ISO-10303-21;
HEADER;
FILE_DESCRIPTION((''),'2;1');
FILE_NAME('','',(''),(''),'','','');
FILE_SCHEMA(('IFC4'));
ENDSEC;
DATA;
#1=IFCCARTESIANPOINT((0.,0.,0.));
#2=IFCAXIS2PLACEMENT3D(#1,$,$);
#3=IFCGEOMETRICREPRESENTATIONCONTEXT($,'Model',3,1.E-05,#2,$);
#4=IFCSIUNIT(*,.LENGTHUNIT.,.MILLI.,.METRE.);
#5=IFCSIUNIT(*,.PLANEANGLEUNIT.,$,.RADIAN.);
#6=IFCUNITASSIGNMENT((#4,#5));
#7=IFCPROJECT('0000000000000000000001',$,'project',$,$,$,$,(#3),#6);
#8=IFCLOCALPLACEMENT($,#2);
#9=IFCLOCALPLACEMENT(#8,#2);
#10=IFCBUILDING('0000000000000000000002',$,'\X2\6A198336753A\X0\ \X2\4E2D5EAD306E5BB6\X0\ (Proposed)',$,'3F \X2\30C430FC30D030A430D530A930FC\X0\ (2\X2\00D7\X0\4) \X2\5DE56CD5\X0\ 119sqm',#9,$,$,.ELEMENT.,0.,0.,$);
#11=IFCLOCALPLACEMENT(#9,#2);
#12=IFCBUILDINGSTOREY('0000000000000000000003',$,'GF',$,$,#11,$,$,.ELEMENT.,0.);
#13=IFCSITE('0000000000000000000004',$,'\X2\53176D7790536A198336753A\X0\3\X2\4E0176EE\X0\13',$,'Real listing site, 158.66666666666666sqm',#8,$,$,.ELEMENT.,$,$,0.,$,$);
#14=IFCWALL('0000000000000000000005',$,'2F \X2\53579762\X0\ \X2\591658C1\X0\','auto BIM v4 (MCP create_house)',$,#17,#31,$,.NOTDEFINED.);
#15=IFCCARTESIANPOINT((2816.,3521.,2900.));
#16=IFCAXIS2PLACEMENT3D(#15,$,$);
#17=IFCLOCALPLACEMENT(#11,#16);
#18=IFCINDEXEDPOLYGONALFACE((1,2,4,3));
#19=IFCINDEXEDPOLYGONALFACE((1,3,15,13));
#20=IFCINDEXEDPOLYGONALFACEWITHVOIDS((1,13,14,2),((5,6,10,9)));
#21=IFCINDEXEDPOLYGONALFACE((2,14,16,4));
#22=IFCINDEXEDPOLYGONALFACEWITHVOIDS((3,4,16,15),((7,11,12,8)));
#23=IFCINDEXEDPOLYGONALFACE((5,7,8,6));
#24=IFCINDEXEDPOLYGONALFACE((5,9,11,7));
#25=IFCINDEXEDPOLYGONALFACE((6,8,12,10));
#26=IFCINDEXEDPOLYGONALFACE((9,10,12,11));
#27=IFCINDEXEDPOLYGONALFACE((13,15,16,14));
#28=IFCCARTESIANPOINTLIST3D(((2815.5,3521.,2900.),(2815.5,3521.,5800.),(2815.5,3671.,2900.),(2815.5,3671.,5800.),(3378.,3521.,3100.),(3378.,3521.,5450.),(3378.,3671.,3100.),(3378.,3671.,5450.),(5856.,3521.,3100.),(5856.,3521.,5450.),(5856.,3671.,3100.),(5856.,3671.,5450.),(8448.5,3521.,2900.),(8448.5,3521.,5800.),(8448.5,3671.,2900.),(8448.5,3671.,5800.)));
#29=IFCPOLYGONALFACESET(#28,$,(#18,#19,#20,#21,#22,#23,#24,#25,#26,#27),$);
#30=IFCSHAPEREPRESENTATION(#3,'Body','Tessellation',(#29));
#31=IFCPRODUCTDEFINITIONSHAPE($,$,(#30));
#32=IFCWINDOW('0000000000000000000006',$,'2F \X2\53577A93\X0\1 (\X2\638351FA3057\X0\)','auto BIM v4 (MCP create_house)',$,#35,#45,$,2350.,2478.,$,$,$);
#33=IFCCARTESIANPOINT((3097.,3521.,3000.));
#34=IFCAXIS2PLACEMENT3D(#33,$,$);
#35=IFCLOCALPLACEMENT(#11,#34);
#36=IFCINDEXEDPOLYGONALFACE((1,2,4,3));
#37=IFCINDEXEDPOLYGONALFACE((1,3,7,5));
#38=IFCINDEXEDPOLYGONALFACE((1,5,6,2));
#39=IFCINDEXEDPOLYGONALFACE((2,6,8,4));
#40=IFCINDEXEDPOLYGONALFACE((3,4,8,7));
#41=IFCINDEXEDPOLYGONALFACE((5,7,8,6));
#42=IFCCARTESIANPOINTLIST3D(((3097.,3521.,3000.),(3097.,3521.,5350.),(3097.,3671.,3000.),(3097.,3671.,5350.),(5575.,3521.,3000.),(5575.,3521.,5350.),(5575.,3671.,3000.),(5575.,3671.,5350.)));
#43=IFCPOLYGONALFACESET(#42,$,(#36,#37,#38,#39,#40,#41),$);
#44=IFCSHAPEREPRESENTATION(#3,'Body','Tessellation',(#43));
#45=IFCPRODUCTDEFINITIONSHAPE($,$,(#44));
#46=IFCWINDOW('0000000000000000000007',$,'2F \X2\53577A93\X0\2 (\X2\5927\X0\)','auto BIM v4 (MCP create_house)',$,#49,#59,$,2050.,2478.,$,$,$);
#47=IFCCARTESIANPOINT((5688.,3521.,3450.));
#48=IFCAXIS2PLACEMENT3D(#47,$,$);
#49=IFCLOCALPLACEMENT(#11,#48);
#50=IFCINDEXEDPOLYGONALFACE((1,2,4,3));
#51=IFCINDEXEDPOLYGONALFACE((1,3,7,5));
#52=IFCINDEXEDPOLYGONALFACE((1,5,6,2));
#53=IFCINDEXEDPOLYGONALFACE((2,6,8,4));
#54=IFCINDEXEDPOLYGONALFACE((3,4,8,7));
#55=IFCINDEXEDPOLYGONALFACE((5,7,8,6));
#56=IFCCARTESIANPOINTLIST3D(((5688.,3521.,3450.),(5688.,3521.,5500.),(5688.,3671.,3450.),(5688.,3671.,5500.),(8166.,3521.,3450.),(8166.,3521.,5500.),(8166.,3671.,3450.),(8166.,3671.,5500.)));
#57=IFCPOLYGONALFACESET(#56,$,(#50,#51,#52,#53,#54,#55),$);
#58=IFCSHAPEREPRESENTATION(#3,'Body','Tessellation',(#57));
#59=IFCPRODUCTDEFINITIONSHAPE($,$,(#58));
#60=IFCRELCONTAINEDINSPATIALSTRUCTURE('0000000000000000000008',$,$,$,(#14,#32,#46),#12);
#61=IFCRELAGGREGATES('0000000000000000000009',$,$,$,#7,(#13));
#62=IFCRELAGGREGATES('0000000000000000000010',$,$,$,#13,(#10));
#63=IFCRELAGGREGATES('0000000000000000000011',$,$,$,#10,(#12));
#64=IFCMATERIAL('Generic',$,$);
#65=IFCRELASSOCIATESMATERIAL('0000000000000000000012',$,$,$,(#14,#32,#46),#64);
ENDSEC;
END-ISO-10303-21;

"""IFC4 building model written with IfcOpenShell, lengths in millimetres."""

from ifc_helpers import new_model, si_unit, frame, frame_2d, origin, place, context, project, spatial, rectangle, extrude, material, element, fill, save


model = new_model("IFC4")

# Units and contexts
model_context = context("Model", 3, precision=1e-05, world=origin())
ifc_project = project(units=[si_unit("LENGTHUNIT", "METRE", prefix="MILLI"), si_unit("PLANEANGLEUNIT", "RADIAN")], contexts=[model_context])

# Site, building, storey
site_placement = place(None, origin())
site = spatial("IfcSite", under=ifc_project, at=site_placement, Name="北海道標茶町3丁目13", ObjectType="Real listing site, 158.66666666666666sqm", CompositionType="ELEMENT", RefElevation=0.0)
building_placement = place(site_placement, origin())
building = spatial("IfcBuilding", under=site, at=building_placement, Name="標茶町 中庭の家 (Proposed)", ObjectType="3F ツーバイフォー (2×4) 工法 119sqm", CompositionType="ELEMENT", ElevationOfRefHeight=0.0, ElevationOfTerrain=0.0)
storey_placement = place(building_placement, origin())
storey = spatial("IfcBuildingStorey", under=building, at=storey_placement, Name="GF", CompositionType="ELEMENT", Elevation=0.0)

# Shared definitions
ifc_material = material(Name="Generic")

# Wall, openings, windows
wall_1_placement = place(storey_placement, frame((2816.0, 3521.0, 2900.0)))
wall_1 = element("IfcWall", 1, at=wall_1_placement, inside=storey, material=ifc_material, Name="2F 南面 外壁", Description="auto BIM v4 (MCP create_house)", PredefinedType="NOTDEFINED", context=model_context, shape_type="SweptSolid", body=[
    extrude(rectangle(XDim=5633.0, YDim=150.0, at=frame_2d((2816.0, 75.0))), frame((2816.0, 3521.0, 2900.0)), (0.0, 0.0, 1.0), 2900.0),
])
opening_1_placement = place(storey_placement, frame((3097.0, 3521.0, 3000.0)))
opening_1 = element("IfcOpeningElement", 2, at=opening_1_placement, cuts=wall_1, PredefinedType="NOTDEFINED", context=model_context, shape_type="SweptSolid", body=[
    extrude(rectangle(XDim=2478.0, YDim=150.0, at=frame_2d((1239.0, 75.0))), frame((3097.0, 3521.0, 3000.0)), (0.0, 0.0, 1.0), 2350.0),
])
opening_2_placement = place(storey_placement, frame((5688.0, 3521.0, 3450.0)))
opening_2 = element("IfcOpeningElement", 3, at=opening_2_placement, cuts=wall_1, PredefinedType="NOTDEFINED", context=model_context, shape_type="SweptSolid", body=[
    extrude(rectangle(XDim=2478.0, YDim=150.0, at=frame_2d((1239.0, 75.0))), frame((5688.0, 3521.0, 3450.0)), (0.0, 0.0, 1.0), 2050.0),
])
window_1_placement = place(storey_placement, frame((3097.0, 3521.0, 3000.0)))
window_1 = element("IfcWindow", 4, at=window_1_placement, inside=storey, material=ifc_material, Name="2F 南窓1 (掃出し)", Description="auto BIM v4 (MCP create_house)", OverallHeight=2350.0, OverallWidth=2478.0, context=model_context, shape_type="SweptSolid", body=[
    extrude(rectangle(XDim=2478.0, YDim=150.0, at=frame_2d((1239.0, 75.0))), frame((3097.0, 3521.0, 3000.0)), (0.0, 0.0, 1.0), 2350.0),
])
fill(opening_1, window_1)
window_2_placement = place(storey_placement, frame((5688.0, 3521.0, 3450.0)))
window_2 = element("IfcWindow", 5, at=window_2_placement, inside=storey, material=ifc_material, Name="2F 南窓2 (大)", Description="auto BIM v4 (MCP create_house)", OverallHeight=2050.0, OverallWidth=2478.0, context=model_context, shape_type="SweptSolid", body=[
    extrude(rectangle(XDim=2478.0, YDim=150.0, at=frame_2d((1239.0, 75.0))), frame((5688.0, 3521.0, 3450.0)), (0.0, 0.0, 1.0), 2050.0),
])
fill(opening_2, window_2)

save(model, "model.ifc")
